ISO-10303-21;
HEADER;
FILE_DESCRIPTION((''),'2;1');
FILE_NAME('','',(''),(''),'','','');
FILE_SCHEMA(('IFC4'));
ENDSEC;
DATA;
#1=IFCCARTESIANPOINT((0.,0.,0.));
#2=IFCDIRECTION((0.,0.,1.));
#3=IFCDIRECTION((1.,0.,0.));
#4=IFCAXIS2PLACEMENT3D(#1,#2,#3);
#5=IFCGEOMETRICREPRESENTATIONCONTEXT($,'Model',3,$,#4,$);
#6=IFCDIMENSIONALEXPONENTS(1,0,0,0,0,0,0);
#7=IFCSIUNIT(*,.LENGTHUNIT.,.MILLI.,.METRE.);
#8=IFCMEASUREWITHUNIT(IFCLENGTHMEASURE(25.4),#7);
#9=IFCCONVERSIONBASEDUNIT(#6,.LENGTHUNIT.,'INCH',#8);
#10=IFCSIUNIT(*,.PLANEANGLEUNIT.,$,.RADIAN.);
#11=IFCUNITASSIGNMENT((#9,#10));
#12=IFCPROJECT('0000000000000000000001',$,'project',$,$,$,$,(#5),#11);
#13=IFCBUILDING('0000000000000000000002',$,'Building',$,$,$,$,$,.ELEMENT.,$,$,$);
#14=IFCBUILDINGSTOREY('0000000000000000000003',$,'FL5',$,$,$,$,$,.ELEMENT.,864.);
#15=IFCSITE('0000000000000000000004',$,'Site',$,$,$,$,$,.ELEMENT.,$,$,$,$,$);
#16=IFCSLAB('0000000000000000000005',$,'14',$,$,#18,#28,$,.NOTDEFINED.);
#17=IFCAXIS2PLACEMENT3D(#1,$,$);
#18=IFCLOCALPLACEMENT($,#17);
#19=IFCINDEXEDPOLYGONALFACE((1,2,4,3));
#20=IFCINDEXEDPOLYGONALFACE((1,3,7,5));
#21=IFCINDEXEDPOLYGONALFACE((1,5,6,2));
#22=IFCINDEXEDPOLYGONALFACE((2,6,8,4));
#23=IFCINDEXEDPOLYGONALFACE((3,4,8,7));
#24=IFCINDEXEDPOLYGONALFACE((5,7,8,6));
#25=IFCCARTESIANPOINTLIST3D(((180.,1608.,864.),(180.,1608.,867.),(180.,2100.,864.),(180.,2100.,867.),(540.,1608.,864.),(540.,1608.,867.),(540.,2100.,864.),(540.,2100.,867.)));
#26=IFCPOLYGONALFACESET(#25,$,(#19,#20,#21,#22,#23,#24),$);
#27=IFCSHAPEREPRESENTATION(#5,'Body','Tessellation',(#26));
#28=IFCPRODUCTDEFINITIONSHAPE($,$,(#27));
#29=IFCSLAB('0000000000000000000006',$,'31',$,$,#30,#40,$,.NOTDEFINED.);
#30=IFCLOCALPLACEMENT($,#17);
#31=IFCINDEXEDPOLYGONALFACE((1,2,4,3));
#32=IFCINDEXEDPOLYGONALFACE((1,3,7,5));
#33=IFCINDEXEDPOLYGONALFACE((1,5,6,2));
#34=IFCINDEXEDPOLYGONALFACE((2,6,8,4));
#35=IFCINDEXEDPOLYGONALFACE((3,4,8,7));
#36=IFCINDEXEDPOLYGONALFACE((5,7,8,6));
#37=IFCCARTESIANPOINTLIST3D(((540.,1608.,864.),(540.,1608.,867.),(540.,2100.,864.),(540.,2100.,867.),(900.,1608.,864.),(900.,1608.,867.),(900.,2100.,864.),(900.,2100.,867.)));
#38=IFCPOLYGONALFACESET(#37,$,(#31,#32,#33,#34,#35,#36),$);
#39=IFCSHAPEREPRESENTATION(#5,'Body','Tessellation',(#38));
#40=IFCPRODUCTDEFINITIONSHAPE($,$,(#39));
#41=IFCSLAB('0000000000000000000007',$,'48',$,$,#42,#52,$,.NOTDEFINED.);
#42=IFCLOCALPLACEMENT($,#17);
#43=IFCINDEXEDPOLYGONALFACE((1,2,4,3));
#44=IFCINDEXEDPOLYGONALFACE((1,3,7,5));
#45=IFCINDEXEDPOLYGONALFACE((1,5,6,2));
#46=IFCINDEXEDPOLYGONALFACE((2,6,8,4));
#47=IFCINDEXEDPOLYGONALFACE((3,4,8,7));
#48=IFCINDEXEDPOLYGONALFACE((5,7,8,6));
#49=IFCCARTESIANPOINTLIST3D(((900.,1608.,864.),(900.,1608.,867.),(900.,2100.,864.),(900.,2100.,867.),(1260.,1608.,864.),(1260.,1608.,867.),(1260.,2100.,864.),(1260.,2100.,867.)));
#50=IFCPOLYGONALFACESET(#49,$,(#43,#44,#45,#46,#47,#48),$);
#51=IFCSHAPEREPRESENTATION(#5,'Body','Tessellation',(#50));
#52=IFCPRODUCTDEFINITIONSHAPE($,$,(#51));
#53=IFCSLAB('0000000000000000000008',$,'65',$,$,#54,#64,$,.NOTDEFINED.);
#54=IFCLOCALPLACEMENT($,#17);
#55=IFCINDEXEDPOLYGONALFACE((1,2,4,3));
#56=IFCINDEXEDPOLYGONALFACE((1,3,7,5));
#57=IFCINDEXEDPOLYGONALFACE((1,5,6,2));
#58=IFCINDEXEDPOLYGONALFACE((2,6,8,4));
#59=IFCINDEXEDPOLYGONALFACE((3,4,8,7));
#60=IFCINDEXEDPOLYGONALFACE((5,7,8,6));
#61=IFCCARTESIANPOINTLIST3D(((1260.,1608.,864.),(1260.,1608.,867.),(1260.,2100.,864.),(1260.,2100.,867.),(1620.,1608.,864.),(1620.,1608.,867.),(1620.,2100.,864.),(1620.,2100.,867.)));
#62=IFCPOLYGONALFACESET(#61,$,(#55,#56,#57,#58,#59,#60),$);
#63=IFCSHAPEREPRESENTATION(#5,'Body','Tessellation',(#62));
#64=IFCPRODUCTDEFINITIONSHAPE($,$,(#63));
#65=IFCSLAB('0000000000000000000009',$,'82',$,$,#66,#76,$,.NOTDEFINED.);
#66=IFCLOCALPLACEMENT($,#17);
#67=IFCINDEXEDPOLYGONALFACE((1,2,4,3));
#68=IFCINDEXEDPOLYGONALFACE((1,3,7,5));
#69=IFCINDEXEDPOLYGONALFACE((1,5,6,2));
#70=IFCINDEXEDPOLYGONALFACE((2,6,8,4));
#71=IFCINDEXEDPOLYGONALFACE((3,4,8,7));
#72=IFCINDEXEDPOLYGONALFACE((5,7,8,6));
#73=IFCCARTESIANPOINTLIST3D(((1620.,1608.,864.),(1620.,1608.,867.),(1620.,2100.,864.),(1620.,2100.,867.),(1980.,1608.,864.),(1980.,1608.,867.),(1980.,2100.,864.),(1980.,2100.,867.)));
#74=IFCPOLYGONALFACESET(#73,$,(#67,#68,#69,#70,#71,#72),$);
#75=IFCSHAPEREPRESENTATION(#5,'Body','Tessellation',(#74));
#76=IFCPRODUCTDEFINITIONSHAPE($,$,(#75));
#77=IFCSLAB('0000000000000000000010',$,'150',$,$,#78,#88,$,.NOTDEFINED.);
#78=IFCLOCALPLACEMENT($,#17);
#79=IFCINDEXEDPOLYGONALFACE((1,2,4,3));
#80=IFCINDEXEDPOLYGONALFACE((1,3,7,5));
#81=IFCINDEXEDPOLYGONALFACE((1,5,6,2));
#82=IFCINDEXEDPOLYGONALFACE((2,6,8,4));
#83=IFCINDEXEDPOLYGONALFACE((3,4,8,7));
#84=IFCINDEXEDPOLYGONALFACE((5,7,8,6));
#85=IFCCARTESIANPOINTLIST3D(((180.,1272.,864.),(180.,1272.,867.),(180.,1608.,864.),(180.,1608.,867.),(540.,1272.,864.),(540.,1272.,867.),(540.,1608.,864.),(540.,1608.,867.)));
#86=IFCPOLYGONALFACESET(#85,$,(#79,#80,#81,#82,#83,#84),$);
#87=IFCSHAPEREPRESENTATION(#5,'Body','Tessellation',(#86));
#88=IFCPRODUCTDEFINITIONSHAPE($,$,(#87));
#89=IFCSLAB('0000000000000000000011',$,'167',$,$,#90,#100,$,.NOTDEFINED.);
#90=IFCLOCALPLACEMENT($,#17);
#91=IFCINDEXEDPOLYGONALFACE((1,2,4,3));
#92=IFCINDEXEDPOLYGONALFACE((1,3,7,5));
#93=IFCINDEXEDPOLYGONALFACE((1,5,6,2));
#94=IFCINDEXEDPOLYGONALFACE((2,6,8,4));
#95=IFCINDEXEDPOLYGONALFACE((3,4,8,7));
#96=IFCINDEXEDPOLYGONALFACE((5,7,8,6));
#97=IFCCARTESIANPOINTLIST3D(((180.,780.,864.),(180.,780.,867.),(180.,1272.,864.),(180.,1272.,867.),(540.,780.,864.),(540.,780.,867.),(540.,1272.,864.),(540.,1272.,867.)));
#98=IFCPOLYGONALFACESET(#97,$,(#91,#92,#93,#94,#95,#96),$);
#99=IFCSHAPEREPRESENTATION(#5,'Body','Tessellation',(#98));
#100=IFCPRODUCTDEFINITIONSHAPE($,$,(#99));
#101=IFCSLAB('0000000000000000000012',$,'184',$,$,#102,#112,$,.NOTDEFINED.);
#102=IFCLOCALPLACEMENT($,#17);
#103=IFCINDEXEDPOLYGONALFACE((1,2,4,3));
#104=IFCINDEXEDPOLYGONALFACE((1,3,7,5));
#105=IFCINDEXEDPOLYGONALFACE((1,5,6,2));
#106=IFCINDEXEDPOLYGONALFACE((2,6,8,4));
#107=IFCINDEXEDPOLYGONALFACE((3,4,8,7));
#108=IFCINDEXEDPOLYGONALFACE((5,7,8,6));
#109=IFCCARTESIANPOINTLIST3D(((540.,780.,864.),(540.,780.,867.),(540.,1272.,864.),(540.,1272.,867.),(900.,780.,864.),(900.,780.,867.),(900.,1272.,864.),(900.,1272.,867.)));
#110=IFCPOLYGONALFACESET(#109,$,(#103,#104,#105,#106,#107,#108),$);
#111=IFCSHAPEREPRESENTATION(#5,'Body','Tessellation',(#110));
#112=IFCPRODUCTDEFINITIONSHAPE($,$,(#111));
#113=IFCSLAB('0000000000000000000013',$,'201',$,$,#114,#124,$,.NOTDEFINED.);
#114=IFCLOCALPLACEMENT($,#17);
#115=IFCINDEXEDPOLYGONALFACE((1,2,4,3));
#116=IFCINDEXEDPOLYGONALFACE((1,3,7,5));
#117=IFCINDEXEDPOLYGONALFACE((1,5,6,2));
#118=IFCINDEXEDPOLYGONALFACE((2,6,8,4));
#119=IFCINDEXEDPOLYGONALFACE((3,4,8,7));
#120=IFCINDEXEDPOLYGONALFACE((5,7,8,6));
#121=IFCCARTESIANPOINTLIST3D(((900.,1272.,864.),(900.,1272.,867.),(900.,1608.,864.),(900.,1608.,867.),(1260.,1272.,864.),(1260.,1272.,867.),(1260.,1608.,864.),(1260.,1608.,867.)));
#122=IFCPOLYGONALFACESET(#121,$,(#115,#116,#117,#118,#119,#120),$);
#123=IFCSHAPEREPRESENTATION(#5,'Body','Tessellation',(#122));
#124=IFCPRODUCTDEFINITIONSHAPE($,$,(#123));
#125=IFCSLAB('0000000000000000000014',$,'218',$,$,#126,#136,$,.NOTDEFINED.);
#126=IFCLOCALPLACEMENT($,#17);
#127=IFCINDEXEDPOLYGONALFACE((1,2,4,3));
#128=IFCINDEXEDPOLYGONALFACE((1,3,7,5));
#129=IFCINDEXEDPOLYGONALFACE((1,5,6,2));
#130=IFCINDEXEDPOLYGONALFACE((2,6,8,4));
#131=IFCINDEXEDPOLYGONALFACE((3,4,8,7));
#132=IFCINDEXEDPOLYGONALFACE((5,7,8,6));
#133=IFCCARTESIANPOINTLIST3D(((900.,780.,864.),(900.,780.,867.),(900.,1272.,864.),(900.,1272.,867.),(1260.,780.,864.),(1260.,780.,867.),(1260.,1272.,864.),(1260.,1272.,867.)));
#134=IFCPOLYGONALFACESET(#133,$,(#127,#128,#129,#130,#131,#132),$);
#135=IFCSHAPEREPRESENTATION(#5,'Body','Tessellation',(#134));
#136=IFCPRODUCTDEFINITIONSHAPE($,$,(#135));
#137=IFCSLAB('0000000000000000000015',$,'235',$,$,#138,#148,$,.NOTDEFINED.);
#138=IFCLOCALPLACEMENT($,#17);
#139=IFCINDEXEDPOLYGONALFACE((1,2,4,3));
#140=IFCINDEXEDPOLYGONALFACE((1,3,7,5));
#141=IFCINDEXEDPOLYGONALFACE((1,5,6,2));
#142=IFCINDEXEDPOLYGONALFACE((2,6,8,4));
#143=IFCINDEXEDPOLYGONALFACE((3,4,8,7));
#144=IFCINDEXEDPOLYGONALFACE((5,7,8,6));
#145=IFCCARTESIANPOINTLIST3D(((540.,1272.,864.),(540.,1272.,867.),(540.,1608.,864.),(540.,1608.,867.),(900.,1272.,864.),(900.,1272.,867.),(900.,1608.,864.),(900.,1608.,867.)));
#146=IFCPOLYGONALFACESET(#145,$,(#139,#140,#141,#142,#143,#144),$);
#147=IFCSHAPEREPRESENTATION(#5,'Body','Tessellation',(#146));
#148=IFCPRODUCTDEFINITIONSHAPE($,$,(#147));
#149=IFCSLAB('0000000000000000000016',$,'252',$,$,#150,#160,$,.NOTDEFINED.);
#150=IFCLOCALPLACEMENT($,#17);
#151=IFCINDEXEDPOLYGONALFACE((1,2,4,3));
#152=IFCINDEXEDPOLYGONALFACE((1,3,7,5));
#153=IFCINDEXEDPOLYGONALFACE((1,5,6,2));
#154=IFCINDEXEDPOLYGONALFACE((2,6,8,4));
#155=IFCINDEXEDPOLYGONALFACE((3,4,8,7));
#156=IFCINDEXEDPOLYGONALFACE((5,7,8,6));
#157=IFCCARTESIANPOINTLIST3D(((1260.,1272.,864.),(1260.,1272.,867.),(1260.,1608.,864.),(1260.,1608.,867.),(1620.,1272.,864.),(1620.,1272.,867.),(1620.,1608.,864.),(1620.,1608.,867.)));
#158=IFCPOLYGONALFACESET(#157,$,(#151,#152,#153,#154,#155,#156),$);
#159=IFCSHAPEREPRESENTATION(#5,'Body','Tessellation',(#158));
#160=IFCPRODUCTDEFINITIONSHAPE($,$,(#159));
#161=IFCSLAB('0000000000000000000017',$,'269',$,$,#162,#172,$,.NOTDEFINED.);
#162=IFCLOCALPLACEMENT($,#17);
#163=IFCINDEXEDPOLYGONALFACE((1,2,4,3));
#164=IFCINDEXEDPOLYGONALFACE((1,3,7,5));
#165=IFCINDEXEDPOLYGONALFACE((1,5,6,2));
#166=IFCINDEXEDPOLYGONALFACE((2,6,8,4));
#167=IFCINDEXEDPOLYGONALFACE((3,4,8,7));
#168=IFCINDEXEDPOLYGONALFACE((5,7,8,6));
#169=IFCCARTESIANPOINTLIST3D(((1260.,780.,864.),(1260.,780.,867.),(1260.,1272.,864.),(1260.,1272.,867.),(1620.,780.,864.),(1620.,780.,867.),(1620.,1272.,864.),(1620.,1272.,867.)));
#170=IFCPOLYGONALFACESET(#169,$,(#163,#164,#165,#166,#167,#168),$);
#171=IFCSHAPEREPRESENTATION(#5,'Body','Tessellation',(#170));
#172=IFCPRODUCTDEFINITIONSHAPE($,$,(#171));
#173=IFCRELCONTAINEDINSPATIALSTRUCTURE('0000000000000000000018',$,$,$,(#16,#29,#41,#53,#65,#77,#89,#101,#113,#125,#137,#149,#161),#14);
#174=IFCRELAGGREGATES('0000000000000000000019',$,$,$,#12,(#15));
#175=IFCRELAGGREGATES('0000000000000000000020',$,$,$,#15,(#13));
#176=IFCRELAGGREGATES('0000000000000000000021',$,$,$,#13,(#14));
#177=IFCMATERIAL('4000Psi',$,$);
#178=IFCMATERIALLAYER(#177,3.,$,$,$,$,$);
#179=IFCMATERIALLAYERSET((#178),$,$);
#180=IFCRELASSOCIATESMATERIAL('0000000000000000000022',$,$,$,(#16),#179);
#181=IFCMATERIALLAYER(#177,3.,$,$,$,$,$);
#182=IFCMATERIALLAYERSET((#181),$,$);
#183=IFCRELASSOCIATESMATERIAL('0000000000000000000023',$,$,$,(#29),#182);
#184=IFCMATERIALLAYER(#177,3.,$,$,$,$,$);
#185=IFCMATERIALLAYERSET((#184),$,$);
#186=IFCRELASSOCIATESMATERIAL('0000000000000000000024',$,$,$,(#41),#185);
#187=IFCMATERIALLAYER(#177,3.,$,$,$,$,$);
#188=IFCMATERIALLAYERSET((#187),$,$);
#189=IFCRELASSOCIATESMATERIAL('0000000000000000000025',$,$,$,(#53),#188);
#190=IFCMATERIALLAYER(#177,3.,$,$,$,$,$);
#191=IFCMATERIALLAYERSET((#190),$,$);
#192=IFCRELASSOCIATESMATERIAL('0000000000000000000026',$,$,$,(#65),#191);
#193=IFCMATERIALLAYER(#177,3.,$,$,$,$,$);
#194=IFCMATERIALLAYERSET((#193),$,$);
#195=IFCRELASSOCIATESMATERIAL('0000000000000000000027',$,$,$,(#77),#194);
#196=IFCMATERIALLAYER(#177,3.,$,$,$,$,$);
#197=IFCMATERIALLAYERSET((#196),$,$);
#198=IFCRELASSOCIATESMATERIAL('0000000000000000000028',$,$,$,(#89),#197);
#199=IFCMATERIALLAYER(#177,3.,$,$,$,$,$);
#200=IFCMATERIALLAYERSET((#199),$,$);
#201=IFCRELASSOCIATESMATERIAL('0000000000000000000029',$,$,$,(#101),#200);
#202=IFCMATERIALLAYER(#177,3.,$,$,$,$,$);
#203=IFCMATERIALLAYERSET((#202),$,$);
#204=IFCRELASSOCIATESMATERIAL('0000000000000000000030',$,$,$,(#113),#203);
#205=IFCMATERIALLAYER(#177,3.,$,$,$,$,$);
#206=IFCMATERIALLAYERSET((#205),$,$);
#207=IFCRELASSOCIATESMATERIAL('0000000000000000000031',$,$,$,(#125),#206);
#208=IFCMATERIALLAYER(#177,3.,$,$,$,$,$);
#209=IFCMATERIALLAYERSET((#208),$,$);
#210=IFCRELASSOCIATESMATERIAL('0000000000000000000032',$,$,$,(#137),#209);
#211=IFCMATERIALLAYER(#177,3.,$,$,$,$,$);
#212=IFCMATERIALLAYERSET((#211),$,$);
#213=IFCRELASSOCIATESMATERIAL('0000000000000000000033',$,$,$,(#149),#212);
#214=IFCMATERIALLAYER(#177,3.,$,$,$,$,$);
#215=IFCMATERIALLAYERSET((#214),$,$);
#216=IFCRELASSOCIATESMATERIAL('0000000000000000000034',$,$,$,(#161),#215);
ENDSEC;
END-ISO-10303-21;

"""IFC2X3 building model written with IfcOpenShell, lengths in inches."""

from ifc_helpers import new_model, entity, si_unit, converted_unit, frame, origin_with_axes, place, context, project, spatial, polyline, outline, extrude, material, layer, layer_set, layer_usage, element, save


model = new_model("IFC2X3")

# Units and contexts
model_context = context("Model", 3, world=origin_with_axes())
ifc_project = project(units=[converted_unit("LENGTHUNIT", "INCH", entity("IfcLengthMeasure", 25.4), si_unit("LENGTHUNIT", "METRE", prefix="MILLI"), dimensions=[1, 0, 0, 0, 0, 0, 0]), si_unit("PLANEANGLEUNIT", "RADIAN")], contexts=[model_context])

# Site, building, storey
site = spatial("IfcSite", under=ifc_project, Name="Site", CompositionType="ELEMENT")
building = spatial("IfcBuilding", under=site, Name="Building", CompositionType="ELEMENT")
storey = spatial("IfcBuildingStorey", under=building, Name="FL5", CompositionType="ELEMENT", Elevation=864.0)

# Slabs
ifc_material_1 = material(Name="4000Psi")
ifc_layer_1 = layer(ifc_material_1, 3.0)
ifc_layer_set_1 = layer_set([ifc_layer_1])
ifc_layer_usage_1 = layer_usage(ifc_layer_set_1, "AXIS2", "POSITIVE", -3.0)
slab_1_placement = place(None, frame((180.0, 1608.0, 864.0), z_axis=(0.0, 0.0, 1.0), x_axis=(1.0, 0.0, 0.0)))
element("IfcSlab", 1, at=slab_1_placement, inside=storey, material=ifc_layer_usage_1, Name="14", PredefinedType="NOTDEFINED", context=model_context, shape_type="SweptSolid", body=[
    extrude(outline(polyline([(0.0, 0.0), (360.0, 0.0), (360.0, 492.0), (0.0, 492.0), (0.0, 0.0)])), origin_with_axes(), (0.0, 0.0, 1.0), 3.0),
])
ifc_layer_2 = layer(ifc_material_1, 3.0)
ifc_layer_set_2 = layer_set([ifc_layer_2])
ifc_layer_usage_2 = layer_usage(ifc_layer_set_2, "AXIS2", "POSITIVE", -3.0)
slab_2_placement = place(None, frame((540.0, 1608.0, 864.0), z_axis=(0.0, 0.0, 1.0), x_axis=(1.0, 0.0, 0.0)))
element("IfcSlab", 2, at=slab_2_placement, inside=storey, material=ifc_layer_usage_2, Name="31", PredefinedType="NOTDEFINED", context=model_context, shape_type="SweptSolid", body=[
    extrude(outline(polyline([(0.0, 0.0), (360.0, 0.0), (360.0, 492.0), (0.0, 492.0), (0.0, 0.0)])), origin_with_axes(), (0.0, 0.0, 1.0), 3.0),
])
ifc_layer_3 = layer(ifc_material_1, 3.0)
ifc_layer_set_3 = layer_set([ifc_layer_3])
ifc_layer_usage_3 = layer_usage(ifc_layer_set_3, "AXIS2", "POSITIVE", -3.0)
slab_3_placement = place(None, frame((900.0, 1608.0, 864.0), z_axis=(0.0, 0.0, 1.0), x_axis=(1.0, 0.0, 0.0)))
element("IfcSlab", 3, at=slab_3_placement, inside=storey, material=ifc_layer_usage_3, Name="48", PredefinedType="NOTDEFINED", context=model_context, shape_type="SweptSolid", body=[
    extrude(outline(polyline([(0.0, 0.0), (360.0, 0.0), (360.0, 492.0), (0.0, 492.0), (0.0, 0.0)])), origin_with_axes(), (0.0, 0.0, 1.0), 3.0),
])
ifc_layer_4 = layer(ifc_material_1, 3.0)
ifc_layer_set_4 = layer_set([ifc_layer_4])
ifc_layer_usage_4 = layer_usage(ifc_layer_set_4, "AXIS2", "POSITIVE", -3.0)
slab_4_placement = place(None, frame((1260.0, 1608.0, 864.0), z_axis=(0.0, 0.0, 1.0), x_axis=(1.0, 0.0, 0.0)))
element("IfcSlab", 4, at=slab_4_placement, inside=storey, material=ifc_layer_usage_4, Name="65", PredefinedType="NOTDEFINED", context=model_context, shape_type="SweptSolid", body=[
    extrude(outline(polyline([(0.0, 0.0), (360.0, 0.0), (360.0, 492.0), (0.0, 492.0), (0.0, 0.0)])), origin_with_axes(), (0.0, 0.0, 1.0), 3.0),
])
ifc_layer_5 = layer(ifc_material_1, 3.0)
ifc_layer_set_5 = layer_set([ifc_layer_5])
ifc_layer_usage_5 = layer_usage(ifc_layer_set_5, "AXIS2", "POSITIVE", -3.0)
slab_5_placement = place(None, frame((1620.0, 1608.0, 864.0), z_axis=(0.0, 0.0, 1.0), x_axis=(1.0, 0.0, 0.0)))
element("IfcSlab", 5, at=slab_5_placement, inside=storey, material=ifc_layer_usage_5, Name="82", PredefinedType="NOTDEFINED", context=model_context, shape_type="SweptSolid", body=[
    extrude(outline(polyline([(0.0, 0.0), (360.0, 0.0), (360.0, 492.0), (0.0, 492.0), (0.0, 0.0)])), origin_with_axes(), (0.0, 0.0, 1.0), 3.0),
])
ifc_layer_6 = layer(ifc_material_1, 3.0)
ifc_layer_set_6 = layer_set([ifc_layer_6])
ifc_layer_usage_6 = layer_usage(ifc_layer_set_6, "AXIS2", "POSITIVE", -3.0)
slab_6_placement = place(None, frame((180.0, 1272.0, 864.0), z_axis=(0.0, 0.0, 1.0), x_axis=(1.0, 0.0, 0.0)))
element("IfcSlab", 6, at=slab_6_placement, inside=storey, material=ifc_layer_usage_6, Name="150", PredefinedType="NOTDEFINED", context=model_context, shape_type="SweptSolid", body=[
    extrude(outline(polyline([(0.0, 0.0), (360.0, 0.0), (360.0, 336.0), (0.0, 336.0), (0.0, 0.0)])), origin_with_axes(), (0.0, 0.0, 1.0), 3.0),
])
ifc_layer_7 = layer(ifc_material_1, 3.0)
ifc_layer_set_7 = layer_set([ifc_layer_7])
ifc_layer_usage_7 = layer_usage(ifc_layer_set_7, "AXIS2", "POSITIVE", -3.0)
slab_7_placement = place(None, frame((180.0, 780.0, 864.0), z_axis=(0.0, 0.0, 1.0), x_axis=(1.0, 0.0, 0.0)))
element("IfcSlab", 7, at=slab_7_placement, inside=storey, material=ifc_layer_usage_7, Name="167", PredefinedType="NOTDEFINED", context=model_context, shape_type="SweptSolid", body=[
    extrude(outline(polyline([(0.0, 0.0), (360.0, 0.0), (360.0, 492.0), (0.0, 492.0), (0.0, 0.0)])), origin_with_axes(), (0.0, 0.0, 1.0), 3.0),
])
ifc_layer_8 = layer(ifc_material_1, 3.0)
ifc_layer_set_8 = layer_set([ifc_layer_8])
ifc_layer_usage_8 = layer_usage(ifc_layer_set_8, "AXIS2", "POSITIVE", -3.0)
slab_8_placement = place(None, frame((540.0, 780.0, 864.0), z_axis=(0.0, 0.0, 1.0), x_axis=(1.0, 0.0, 0.0)))
element("IfcSlab", 8, at=slab_8_placement, inside=storey, material=ifc_layer_usage_8, Name="184", PredefinedType="NOTDEFINED", context=model_context, shape_type="SweptSolid", body=[
    extrude(outline(polyline([(0.0, 0.0), (360.0, 0.0), (360.0, 492.0), (0.0, 492.0), (0.0, 0.0)])), origin_with_axes(), (0.0, 0.0, 1.0), 3.0),
])
ifc_layer_9 = layer(ifc_material_1, 3.0)
ifc_layer_set_9 = layer_set([ifc_layer_9])
ifc_layer_usage_9 = layer_usage(ifc_layer_set_9, "AXIS2", "POSITIVE", -3.0)
slab_9_placement = place(None, frame((900.0, 1272.0, 864.0), z_axis=(0.0, 0.0, 1.0), x_axis=(1.0, 0.0, 0.0)))
element("IfcSlab", 9, at=slab_9_placement, inside=storey, material=ifc_layer_usage_9, Name="201", PredefinedType="NOTDEFINED", context=model_context, shape_type="SweptSolid", body=[
    extrude(outline(polyline([(0.0, 0.0), (360.0, 0.0), (360.0, 336.0), (0.0, 336.0), (0.0, 0.0)])), origin_with_axes(), (0.0, 0.0, 1.0), 3.0),
])
ifc_layer_10 = layer(ifc_material_1, 3.0)
ifc_layer_set_10 = layer_set([ifc_layer_10])
ifc_layer_usage_10 = layer_usage(ifc_layer_set_10, "AXIS2", "POSITIVE", -3.0)
slab_10_placement = place(None, frame((900.0, 780.0, 864.0), z_axis=(0.0, 0.0, 1.0), x_axis=(1.0, 0.0, 0.0)))
element("IfcSlab", 10, at=slab_10_placement, inside=storey, material=ifc_layer_usage_10, Name="218", PredefinedType="NOTDEFINED", context=model_context, shape_type="SweptSolid", body=[
    extrude(outline(polyline([(0.0, 0.0), (360.0, 0.0), (360.0, 492.0), (0.0, 492.0), (0.0, 0.0)])), origin_with_axes(), (0.0, 0.0, 1.0), 3.0),
])
ifc_layer_11 = layer(ifc_material_1, 3.0)
ifc_layer_set_11 = layer_set([ifc_layer_11])
ifc_layer_usage_11 = layer_usage(ifc_layer_set_11, "AXIS2", "POSITIVE", -3.0)
slab_11_placement = place(None, frame((540.0, 1272.0, 864.0), z_axis=(0.0, 0.0, 1.0), x_axis=(1.0, 0.0, 0.0)))
element("IfcSlab", 11, at=slab_11_placement, inside=storey, material=ifc_layer_usage_11, Name="235", PredefinedType="NOTDEFINED", context=model_context, shape_type="SweptSolid", body=[
    extrude(outline(polyline([(0.0, 0.0), (360.0, 0.0), (360.0, 336.0), (0.0, 336.0), (0.0, 0.0)])), origin_with_axes(), (0.0, 0.0, 1.0), 3.0),
])
ifc_layer_12 = layer(ifc_material_1, 3.0)
ifc_layer_set_12 = layer_set([ifc_layer_12])
ifc_layer_usage_12 = layer_usage(ifc_layer_set_12, "AXIS2", "POSITIVE", -3.0)
slab_12_placement = place(None, frame((1260.0, 1272.0, 864.0), z_axis=(0.0, 0.0, 1.0), x_axis=(1.0, 0.0, 0.0)))
element("IfcSlab", 12, at=slab_12_placement, inside=storey, material=ifc_layer_usage_12, Name="252", PredefinedType="NOTDEFINED", context=model_context, shape_type="SweptSolid", body=[
    extrude(outline(polyline([(0.0, 0.0), (360.0, 0.0), (360.0, 336.0), (0.0, 336.0), (0.0, 0.0)])), origin_with_axes(), (0.0, 0.0, 1.0), 3.0),
])
ifc_layer_13 = layer(ifc_material_1, 3.0)
ifc_layer_set_13 = layer_set([ifc_layer_13])
ifc_layer_usage_13 = layer_usage(ifc_layer_set_13, "AXIS2", "POSITIVE", -3.0)
slab_13_placement = place(None, frame((1260.0, 780.0, 864.0), z_axis=(0.0, 0.0, 1.0), x_axis=(1.0, 0.0, 0.0)))
element("IfcSlab", 13, at=slab_13_placement, inside=storey, material=ifc_layer_usage_13, Name="269", PredefinedType="NOTDEFINED", context=model_context, shape_type="SweptSolid", body=[
    extrude(outline(polyline([(0.0, 0.0), (360.0, 0.0), (360.0, 492.0), (0.0, 492.0), (0.0, 0.0)])), origin_with_axes(), (0.0, 0.0, 1.0), 3.0),
])

save(model, "model.ifc")
